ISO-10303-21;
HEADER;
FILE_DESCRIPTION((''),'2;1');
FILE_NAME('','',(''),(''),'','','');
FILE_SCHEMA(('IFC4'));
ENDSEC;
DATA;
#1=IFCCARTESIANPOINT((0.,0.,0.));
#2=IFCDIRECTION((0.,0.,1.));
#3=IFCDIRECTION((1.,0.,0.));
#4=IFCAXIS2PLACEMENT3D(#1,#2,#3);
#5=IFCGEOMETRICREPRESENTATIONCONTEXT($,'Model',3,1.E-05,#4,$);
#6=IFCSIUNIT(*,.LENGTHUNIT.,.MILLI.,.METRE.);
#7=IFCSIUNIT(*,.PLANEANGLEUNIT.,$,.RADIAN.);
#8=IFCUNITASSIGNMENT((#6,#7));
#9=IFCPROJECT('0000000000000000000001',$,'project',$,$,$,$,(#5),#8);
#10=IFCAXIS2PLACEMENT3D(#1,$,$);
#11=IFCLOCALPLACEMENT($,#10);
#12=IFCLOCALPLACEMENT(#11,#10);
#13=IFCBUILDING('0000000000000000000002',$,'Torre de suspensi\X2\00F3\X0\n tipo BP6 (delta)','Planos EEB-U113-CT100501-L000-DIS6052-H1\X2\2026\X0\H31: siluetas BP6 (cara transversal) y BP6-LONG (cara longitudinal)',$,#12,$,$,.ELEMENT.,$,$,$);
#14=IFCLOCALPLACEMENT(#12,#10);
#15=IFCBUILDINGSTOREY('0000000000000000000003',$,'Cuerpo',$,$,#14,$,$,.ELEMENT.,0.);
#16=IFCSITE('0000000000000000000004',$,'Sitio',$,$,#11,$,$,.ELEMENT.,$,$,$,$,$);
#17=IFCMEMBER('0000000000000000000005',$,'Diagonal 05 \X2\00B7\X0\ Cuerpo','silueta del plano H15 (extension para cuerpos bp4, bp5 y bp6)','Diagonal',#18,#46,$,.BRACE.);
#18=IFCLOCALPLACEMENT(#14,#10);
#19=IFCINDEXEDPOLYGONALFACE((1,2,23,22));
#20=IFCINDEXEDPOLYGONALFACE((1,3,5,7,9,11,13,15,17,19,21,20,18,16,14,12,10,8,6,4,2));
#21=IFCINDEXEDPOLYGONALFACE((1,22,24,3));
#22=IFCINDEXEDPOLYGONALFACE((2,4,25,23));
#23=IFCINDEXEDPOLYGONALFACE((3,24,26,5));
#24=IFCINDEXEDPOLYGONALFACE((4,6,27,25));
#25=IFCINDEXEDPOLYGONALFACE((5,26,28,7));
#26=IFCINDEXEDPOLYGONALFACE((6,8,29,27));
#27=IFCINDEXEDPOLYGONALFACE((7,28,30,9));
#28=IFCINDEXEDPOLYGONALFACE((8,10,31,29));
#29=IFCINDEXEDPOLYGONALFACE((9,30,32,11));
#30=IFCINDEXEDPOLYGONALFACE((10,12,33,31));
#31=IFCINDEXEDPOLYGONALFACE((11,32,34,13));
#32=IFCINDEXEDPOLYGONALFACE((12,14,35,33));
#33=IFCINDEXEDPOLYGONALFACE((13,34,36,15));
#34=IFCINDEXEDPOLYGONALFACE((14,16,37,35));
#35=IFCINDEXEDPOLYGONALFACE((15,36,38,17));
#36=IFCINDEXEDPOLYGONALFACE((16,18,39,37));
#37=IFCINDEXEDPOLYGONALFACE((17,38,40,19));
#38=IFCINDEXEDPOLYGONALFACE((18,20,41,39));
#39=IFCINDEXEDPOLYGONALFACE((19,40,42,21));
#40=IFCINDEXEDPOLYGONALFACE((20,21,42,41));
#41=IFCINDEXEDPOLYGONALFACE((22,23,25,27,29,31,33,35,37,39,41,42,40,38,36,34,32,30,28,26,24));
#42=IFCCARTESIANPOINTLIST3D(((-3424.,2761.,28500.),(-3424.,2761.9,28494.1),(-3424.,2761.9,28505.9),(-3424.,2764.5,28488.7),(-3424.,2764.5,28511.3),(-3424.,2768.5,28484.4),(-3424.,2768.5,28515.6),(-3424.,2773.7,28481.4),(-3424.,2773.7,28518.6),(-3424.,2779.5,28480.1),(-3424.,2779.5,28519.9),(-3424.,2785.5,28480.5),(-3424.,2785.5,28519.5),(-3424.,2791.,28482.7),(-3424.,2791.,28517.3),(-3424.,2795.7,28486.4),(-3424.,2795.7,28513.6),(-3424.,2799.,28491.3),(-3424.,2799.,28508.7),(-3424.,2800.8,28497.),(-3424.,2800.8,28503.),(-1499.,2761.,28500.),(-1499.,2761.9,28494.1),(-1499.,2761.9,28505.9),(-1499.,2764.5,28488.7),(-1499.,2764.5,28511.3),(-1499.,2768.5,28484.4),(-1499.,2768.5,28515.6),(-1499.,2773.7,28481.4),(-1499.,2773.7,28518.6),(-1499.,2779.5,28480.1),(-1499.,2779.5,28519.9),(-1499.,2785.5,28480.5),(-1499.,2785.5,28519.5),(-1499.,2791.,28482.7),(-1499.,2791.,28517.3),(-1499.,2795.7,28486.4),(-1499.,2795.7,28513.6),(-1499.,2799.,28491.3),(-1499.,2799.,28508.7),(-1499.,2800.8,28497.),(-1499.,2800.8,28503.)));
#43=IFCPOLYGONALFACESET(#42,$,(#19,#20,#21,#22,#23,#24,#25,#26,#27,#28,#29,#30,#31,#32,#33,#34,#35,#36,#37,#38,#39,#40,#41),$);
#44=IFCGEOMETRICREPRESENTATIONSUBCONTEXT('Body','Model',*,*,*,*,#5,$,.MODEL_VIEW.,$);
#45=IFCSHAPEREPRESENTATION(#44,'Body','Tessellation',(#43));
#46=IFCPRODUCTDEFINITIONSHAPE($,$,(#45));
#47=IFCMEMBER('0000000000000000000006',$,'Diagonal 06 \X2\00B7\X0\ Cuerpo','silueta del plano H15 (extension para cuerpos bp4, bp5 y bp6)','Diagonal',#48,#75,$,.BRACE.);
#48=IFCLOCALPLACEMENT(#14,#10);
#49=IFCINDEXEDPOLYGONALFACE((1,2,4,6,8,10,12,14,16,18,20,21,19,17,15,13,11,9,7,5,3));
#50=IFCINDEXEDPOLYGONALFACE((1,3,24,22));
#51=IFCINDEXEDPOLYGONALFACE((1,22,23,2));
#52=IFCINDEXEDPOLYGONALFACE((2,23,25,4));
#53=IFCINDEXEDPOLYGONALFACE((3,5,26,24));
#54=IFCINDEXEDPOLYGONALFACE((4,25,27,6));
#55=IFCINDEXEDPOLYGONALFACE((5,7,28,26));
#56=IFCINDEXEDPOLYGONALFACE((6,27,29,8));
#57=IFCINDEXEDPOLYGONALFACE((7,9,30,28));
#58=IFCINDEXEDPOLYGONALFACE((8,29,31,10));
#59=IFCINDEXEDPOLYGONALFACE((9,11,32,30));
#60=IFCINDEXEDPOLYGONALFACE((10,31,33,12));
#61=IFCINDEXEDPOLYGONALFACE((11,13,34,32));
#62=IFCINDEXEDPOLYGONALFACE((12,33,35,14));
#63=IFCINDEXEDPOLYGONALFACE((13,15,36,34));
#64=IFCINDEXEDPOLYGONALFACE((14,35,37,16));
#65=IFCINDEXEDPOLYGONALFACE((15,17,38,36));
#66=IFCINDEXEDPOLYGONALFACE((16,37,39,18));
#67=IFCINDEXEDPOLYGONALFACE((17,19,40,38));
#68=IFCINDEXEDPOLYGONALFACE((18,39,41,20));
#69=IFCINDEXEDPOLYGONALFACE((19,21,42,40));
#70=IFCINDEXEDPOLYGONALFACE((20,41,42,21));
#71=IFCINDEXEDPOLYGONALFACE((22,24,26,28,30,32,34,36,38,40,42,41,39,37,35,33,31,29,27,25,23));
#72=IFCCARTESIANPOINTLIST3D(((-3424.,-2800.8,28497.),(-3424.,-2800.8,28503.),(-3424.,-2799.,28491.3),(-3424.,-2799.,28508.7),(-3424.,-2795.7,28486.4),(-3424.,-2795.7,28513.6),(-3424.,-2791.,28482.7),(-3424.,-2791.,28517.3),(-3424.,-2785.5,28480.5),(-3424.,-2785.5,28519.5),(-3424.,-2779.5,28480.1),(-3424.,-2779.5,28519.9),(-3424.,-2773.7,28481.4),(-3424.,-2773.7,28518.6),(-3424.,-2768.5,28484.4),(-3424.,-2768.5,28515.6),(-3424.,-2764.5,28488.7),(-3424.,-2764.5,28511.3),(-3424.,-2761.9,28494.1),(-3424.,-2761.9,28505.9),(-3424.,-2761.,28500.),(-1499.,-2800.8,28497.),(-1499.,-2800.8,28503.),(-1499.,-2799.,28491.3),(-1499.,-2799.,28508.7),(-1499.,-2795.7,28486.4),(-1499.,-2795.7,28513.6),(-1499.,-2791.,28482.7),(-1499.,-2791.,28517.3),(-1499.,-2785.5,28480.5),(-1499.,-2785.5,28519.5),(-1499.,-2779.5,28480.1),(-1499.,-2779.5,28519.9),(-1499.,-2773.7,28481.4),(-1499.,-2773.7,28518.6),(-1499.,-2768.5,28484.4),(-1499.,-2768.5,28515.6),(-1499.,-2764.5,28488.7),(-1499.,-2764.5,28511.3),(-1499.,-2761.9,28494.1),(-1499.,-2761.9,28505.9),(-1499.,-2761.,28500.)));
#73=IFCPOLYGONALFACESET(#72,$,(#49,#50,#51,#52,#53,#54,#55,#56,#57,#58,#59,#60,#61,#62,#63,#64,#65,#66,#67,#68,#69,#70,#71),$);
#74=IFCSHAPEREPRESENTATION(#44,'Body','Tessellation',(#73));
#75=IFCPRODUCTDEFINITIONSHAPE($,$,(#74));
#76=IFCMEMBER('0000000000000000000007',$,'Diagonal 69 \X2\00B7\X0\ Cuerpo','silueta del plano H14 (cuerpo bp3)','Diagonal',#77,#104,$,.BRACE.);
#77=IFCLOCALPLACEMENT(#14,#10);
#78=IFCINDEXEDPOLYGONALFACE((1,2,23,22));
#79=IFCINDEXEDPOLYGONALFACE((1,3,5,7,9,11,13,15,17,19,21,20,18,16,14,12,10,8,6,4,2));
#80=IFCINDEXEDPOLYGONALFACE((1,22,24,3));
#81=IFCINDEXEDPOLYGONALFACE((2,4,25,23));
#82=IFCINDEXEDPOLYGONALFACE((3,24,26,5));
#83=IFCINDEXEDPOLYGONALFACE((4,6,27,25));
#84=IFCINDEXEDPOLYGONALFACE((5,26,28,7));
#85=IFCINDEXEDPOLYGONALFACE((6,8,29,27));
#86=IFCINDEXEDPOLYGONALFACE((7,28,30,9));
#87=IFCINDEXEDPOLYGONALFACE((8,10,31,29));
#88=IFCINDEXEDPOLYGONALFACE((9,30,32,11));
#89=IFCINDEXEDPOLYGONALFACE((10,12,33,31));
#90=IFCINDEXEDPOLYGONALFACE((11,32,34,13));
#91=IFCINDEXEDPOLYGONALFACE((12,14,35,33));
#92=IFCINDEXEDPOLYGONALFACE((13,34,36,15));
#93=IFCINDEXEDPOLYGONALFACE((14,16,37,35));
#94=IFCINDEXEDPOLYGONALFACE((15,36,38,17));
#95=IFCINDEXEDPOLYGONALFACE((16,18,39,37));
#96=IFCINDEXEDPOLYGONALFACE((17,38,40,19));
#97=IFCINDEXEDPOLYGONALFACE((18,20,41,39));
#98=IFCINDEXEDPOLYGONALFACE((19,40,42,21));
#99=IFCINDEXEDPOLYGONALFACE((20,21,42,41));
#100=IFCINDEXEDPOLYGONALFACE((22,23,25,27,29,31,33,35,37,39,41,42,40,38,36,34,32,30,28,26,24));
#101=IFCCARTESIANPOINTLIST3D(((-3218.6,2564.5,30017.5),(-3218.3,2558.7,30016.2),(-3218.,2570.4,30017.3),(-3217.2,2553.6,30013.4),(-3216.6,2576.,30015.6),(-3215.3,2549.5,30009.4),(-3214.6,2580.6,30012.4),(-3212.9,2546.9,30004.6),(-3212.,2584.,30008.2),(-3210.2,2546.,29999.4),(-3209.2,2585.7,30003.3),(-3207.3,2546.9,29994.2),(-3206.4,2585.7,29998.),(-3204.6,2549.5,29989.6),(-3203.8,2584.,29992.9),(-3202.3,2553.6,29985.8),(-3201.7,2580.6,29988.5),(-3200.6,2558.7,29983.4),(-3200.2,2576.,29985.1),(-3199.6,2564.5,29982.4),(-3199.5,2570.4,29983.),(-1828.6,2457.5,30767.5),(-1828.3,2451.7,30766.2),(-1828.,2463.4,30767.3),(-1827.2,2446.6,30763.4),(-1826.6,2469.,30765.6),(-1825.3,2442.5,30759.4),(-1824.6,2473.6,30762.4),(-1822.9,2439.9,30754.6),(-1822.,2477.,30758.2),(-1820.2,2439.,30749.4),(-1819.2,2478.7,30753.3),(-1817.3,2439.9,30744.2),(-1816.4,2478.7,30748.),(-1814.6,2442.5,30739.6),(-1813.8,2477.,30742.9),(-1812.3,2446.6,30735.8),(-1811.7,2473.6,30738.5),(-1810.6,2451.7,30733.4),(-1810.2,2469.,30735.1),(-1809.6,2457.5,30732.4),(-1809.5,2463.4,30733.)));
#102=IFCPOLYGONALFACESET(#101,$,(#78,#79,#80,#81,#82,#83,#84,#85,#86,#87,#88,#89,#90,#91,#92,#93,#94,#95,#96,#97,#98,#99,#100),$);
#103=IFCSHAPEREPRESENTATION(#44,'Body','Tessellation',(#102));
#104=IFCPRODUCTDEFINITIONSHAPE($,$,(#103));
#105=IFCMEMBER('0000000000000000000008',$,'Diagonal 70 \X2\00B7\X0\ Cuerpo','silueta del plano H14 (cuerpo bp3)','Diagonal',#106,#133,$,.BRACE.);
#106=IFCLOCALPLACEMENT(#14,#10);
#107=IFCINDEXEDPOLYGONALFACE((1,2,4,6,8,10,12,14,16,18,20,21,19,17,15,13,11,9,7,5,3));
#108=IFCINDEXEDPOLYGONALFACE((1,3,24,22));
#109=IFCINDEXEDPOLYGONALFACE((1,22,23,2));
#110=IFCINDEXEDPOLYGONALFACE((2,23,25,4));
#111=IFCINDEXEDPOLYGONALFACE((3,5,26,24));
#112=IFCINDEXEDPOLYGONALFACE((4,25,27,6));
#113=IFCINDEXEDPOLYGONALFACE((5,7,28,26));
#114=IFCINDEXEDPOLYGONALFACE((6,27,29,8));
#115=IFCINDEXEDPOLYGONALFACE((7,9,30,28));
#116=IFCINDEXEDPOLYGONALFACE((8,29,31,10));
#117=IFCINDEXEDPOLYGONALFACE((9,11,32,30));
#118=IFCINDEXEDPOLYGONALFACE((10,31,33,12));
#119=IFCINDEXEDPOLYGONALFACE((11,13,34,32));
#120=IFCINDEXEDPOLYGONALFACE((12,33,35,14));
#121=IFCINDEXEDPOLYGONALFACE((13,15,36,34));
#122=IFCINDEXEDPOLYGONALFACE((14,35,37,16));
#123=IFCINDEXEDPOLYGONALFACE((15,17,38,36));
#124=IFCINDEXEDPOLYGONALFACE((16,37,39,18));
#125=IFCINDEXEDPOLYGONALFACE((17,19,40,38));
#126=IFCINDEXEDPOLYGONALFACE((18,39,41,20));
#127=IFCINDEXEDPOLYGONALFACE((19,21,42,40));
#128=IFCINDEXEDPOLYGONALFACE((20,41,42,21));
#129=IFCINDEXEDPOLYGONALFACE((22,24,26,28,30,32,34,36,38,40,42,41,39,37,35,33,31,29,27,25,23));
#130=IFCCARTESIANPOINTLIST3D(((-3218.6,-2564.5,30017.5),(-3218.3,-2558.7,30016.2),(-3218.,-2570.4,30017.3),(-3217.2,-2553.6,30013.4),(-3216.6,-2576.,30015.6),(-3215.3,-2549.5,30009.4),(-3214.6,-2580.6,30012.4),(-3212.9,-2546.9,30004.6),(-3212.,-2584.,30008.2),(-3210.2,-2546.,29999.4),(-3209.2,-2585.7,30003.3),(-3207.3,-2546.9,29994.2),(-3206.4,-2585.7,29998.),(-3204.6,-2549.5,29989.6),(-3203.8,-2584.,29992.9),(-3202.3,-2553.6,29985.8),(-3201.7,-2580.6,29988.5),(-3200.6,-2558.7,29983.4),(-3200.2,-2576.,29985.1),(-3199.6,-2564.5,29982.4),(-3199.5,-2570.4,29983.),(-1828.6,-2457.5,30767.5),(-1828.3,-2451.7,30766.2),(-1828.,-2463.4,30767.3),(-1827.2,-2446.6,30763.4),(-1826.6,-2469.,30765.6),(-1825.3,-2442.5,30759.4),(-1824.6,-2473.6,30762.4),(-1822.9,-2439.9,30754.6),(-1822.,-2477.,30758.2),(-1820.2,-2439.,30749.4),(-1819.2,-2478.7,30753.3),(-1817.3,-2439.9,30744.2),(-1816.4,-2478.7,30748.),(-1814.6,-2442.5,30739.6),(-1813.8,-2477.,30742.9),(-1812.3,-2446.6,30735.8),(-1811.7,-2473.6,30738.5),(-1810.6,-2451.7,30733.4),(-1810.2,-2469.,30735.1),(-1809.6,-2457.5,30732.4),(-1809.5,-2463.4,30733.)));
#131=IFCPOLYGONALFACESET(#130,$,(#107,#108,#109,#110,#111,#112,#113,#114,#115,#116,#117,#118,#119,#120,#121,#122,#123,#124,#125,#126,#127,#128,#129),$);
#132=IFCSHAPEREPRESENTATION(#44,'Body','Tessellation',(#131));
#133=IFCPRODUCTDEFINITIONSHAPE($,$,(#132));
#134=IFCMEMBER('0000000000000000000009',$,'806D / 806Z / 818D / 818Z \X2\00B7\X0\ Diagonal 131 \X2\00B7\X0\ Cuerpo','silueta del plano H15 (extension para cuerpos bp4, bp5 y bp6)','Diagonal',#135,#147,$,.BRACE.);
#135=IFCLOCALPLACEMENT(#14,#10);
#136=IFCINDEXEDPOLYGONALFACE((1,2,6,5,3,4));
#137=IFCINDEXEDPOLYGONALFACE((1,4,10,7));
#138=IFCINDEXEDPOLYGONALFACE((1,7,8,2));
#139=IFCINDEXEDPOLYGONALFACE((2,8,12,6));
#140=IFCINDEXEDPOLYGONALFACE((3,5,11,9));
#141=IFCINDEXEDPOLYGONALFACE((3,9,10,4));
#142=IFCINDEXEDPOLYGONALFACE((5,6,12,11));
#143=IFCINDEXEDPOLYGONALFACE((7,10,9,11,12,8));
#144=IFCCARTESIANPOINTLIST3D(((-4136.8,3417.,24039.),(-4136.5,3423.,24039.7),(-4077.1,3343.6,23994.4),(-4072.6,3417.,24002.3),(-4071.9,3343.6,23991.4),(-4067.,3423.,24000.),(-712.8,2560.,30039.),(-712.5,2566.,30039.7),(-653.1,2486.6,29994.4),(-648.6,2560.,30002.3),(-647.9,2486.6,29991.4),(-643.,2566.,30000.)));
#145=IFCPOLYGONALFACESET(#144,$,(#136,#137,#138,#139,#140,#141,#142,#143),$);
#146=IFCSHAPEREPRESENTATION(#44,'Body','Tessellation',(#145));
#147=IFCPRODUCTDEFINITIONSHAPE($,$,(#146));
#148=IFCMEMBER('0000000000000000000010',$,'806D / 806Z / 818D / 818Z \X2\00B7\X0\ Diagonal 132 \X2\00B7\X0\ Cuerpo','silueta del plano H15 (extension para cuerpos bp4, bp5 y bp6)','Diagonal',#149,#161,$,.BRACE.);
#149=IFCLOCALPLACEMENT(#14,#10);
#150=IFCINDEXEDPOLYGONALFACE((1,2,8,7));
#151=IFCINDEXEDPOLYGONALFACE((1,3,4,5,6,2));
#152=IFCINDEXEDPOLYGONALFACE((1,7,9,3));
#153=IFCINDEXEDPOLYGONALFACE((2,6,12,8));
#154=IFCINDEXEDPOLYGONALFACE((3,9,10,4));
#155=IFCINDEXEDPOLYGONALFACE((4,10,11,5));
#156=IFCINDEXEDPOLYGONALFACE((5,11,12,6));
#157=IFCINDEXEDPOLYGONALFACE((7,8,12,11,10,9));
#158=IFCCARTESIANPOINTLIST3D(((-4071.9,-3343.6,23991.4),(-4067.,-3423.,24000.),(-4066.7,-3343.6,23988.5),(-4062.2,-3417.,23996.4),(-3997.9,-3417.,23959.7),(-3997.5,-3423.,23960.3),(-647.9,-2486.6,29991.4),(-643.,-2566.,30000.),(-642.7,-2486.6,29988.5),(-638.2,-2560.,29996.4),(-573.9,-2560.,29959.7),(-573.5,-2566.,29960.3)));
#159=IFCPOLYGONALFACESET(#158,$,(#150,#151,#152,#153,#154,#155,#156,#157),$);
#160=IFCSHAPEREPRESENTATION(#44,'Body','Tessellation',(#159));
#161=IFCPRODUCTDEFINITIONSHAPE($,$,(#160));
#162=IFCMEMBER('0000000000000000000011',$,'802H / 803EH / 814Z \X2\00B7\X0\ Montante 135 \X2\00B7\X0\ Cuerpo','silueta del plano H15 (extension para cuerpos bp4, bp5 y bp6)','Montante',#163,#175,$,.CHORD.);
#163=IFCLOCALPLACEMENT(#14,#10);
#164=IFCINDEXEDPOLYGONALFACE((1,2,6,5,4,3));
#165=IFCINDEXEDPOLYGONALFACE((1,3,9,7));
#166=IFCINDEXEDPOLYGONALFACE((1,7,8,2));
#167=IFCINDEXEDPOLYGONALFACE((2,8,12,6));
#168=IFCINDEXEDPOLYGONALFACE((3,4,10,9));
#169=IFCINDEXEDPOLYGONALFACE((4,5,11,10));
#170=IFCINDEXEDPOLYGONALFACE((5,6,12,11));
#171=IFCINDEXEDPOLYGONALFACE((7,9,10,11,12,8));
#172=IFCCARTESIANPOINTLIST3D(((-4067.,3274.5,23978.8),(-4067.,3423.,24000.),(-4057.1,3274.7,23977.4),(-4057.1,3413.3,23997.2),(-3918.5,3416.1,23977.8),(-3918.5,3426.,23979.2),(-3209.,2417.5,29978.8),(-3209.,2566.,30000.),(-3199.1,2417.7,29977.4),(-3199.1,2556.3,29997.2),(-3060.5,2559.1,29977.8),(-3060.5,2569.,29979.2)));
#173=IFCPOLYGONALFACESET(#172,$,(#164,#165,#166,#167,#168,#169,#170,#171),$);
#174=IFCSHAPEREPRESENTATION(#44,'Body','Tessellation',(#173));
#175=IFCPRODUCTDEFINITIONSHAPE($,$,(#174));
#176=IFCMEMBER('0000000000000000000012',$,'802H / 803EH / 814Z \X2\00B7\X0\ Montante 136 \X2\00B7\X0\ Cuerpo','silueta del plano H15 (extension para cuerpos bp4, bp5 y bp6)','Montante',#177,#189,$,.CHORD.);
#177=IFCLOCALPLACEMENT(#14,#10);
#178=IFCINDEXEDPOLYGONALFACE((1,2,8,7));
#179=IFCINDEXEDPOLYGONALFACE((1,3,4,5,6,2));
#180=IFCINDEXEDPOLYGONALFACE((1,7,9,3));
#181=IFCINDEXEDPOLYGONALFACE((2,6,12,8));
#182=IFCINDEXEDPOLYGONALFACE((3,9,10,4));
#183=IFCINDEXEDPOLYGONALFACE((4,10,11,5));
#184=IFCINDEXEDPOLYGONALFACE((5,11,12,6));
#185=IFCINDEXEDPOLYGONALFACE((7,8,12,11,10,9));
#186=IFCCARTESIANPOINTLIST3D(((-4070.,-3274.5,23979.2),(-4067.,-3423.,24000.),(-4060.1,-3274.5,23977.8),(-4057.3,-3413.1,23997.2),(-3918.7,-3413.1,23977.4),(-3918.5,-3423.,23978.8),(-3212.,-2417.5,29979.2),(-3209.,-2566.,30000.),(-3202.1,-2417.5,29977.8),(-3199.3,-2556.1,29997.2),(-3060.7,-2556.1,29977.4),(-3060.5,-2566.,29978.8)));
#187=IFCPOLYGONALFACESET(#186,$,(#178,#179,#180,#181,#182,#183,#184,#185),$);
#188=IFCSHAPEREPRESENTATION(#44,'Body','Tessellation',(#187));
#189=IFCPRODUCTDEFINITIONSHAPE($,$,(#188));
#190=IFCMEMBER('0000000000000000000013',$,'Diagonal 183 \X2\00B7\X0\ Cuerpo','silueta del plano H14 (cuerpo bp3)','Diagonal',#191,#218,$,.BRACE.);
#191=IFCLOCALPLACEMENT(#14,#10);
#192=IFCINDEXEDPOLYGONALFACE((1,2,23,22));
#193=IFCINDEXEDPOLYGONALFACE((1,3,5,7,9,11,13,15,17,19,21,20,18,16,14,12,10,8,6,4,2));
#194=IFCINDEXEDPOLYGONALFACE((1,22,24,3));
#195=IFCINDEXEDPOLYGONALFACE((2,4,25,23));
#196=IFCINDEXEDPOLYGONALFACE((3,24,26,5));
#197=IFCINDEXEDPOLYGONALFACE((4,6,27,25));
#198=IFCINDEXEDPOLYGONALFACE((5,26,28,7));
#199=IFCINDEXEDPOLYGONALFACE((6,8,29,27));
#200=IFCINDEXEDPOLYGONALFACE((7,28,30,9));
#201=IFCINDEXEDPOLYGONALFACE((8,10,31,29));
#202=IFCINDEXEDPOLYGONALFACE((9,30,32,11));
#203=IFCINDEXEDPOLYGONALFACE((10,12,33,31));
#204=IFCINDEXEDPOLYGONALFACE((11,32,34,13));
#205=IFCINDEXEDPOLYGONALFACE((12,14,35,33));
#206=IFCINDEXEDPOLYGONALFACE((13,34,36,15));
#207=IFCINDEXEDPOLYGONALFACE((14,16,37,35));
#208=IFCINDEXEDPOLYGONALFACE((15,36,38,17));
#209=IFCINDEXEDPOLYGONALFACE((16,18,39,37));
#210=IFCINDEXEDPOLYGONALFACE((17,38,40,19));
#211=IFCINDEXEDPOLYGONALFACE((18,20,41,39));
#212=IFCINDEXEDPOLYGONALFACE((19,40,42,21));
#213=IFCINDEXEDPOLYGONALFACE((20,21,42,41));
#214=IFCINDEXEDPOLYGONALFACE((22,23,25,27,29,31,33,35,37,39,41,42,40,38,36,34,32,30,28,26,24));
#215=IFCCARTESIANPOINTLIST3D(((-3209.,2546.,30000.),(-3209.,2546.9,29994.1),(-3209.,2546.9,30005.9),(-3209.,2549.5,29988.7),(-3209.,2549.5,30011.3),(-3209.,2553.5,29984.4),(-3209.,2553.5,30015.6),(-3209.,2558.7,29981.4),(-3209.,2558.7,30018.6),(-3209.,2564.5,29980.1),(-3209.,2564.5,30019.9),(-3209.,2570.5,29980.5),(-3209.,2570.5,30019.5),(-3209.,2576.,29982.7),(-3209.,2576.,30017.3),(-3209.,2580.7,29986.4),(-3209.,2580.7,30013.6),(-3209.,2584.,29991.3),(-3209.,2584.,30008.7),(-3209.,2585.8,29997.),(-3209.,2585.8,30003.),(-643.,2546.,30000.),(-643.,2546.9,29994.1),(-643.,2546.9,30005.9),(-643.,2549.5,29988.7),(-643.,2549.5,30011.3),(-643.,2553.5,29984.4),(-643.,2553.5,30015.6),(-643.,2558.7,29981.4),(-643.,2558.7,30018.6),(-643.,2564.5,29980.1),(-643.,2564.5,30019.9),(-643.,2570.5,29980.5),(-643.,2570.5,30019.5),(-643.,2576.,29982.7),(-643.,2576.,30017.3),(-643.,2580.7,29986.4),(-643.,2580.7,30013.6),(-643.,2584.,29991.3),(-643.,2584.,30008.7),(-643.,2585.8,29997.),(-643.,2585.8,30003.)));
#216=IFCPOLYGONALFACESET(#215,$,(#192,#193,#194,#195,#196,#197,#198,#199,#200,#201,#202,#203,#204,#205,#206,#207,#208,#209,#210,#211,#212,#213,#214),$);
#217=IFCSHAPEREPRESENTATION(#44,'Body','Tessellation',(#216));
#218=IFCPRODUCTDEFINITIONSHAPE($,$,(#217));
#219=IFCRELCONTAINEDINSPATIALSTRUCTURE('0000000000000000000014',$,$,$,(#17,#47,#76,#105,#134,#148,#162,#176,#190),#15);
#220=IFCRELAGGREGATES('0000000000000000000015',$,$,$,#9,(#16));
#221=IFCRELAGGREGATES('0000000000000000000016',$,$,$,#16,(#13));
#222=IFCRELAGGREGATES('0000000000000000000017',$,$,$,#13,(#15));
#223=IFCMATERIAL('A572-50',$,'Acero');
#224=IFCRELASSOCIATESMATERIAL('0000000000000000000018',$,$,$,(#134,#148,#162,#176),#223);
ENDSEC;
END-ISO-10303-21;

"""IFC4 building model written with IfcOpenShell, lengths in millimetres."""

from ifc_helpers import new_model, si_unit, frame, frame_2d, origin, origin_with_axes, place, context, subcontext, project, spatial, circle, l_section, extrude, material, element, save


model = new_model("IFC4")

# Units and contexts
model_context = context("Model", 3, precision=1e-05, world=origin_with_axes())
body_context = subcontext(model_context, "Body", "Model", "MODEL_VIEW")
ifc_project = project(units=[si_unit("LENGTHUNIT", "METRE", prefix="MILLI"), si_unit("PLANEANGLEUNIT", "RADIAN")], contexts=[model_context])

# Site, building, storey
site_placement = place(None, origin())
site = spatial("IfcSite", under=ifc_project, at=site_placement, Name="Sitio", CompositionType="ELEMENT")
building_placement = place(site_placement, origin())
building = spatial("IfcBuilding", under=site, at=building_placement, Name="Torre de suspensión tipo BP6 (delta)", Description="Planos EEB-U113-CT100501-L000-DIS6052-H1…H31: siluetas BP6 (cara transversal) y BP6-LONG (cara longitudinal)", CompositionType="ELEMENT")
storey_placement = place(building_placement, origin())
storey = spatial("IfcBuildingStorey", under=building, at=storey_placement, Name="Cuerpo", CompositionType="ELEMENT", Elevation=0.0)

# Members
for number, where, z_axis, x_axis, name in (
    (1, (-1499.0, 2781.0, 28500.0), (-1.0, 0.0, 0.0), (0.0, -1.0, 0.0), "Diagonal 05 · Cuerpo"),
    (2, (-1499.0, -2781.0, 28500.0), (-1.0, 0.0, 0.0), (0.0, 1.0, 0.0), "Diagonal 06 · Cuerpo"),
):
    element("IfcMember", number, at=place(storey_placement, frame(where, z_axis=z_axis, x_axis=x_axis)), inside=storey, Name=name, Description="silueta del plano H15 (extension para cuerpos bp4, bp5 y bp6)", ObjectType="Diagonal", PredefinedType="BRACE", context=body_context, shape_type="SweptSolid", body=[
        extrude(circle(Radius=20.0), None, (0.0, 0.0, 1.0), 1925.0),
    ])
for number, where, z_axis, x_axis, name in (
    (3, (-3209.0, 2566.0, 30000.0), (0.878052, -0.067591, 0.473769), (-0.059484, -0.997713, -0.032096), "Diagonal 69 · Cuerpo"),
    (4, (-3209.0, -2566.0, 30000.0), (0.878052, 0.067591, 0.473769), (-0.059484, 0.997713, -0.032096), "Diagonal 70 · Cuerpo"),
):
    element("IfcMember", number, at=place(storey_placement, frame(where, z_axis=z_axis, x_axis=x_axis)), inside=storey, Name=name, Description="silueta del plano H14 (cuerpo bp3)", ObjectType="Diagonal", PredefinedType="BRACE", context=body_context, shape_type="SweptSolid", body=[
        extrude(circle(Radius=20.0), None, (0.0, 0.0, 1.0), 1583.1),
    ])
ifc_material = material(Name="A572-50", Category="Acero")
for number, where, z_axis, x_axis, name in (
    (5, (-643.0, 2566.0, 30000.0), (-0.49187, 0.123111, -0.861921), (-0.061019, -0.992393, -0.106925), "806D / 806Z / 818D / 818Z · Diagonal 131 · Cuerpo"),
    (6, (-643.0, -2566.0, 30000.0), (-0.49187, -0.123111, -0.861921), (-0.061019, 0.992393, -0.106925), "806D / 806Z / 818D / 818Z · Diagonal 132 · Cuerpo"),
):
    element("IfcMember", number, at=place(storey_placement, frame(where, z_axis=z_axis, x_axis=x_axis)), inside=storey, material=ifc_material, Name=name, Description="silueta del plano H15 (extension para cuerpos bp4, bp5 y bp6)", ObjectType="Diagonal", PredefinedType="BRACE", context=body_context, shape_type="SweptSolid", body=[
        extrude(l_section(Depth=80.0, Width=80.0, Thickness=6.0, at=frame_2d((40.0, 40.0))), None, (0.0, 0.0, 1.0), 6961.2),
    ])
for number, where, z_axis, x_axis, name in (
    (7, (-3209.0, 2566.0, 30000.0), (-0.140166, 0.140002, -0.98018), (0.990128, 0.019819, -0.138757), "802H / 803EH / 814Z · Montante 135 · Cuerpo"),
    (8, (-3209.0, -2566.0, 30000.0), (-0.140166, -0.140002, -0.98018), (-0.019819, 0.990151, -0.138593), "802H / 803EH / 814Z · Montante 136 · Cuerpo"),
):
    element("IfcMember", number, at=place(storey_placement, frame(where, z_axis=z_axis, x_axis=x_axis)), inside=storey, material=ifc_material, Name=name, Description="silueta del plano H15 (extension para cuerpos bp4, bp5 y bp6)", ObjectType="Montante", PredefinedType="CHORD", context=body_context, shape_type="SweptSolid", body=[
        extrude(l_section(Depth=150.0, Width=150.0, Thickness=10.0, at=frame_2d((75.0, 75.0))), None, (0.0, 0.0, 1.0), 6121.3),
    ])
for number, where, z_axis, x_axis, name in (
    (9, (-3209.0, 2566.0, 30000.0), (1.0, 0.0, 0.0), (0.0, -1.0, 0.0), "Diagonal 183 · Cuerpo"),
):
    element("IfcMember", number, at=place(storey_placement, frame(where, z_axis=z_axis, x_axis=x_axis)), inside=storey, Name=name, Description="silueta del plano H14 (cuerpo bp3)", ObjectType="Diagonal", PredefinedType="BRACE", context=body_context, shape_type="SweptSolid", body=[
        extrude(circle(Radius=20.0), None, (0.0, 0.0, 1.0), 2566.0),
    ])

save(model, "model.ifc")
